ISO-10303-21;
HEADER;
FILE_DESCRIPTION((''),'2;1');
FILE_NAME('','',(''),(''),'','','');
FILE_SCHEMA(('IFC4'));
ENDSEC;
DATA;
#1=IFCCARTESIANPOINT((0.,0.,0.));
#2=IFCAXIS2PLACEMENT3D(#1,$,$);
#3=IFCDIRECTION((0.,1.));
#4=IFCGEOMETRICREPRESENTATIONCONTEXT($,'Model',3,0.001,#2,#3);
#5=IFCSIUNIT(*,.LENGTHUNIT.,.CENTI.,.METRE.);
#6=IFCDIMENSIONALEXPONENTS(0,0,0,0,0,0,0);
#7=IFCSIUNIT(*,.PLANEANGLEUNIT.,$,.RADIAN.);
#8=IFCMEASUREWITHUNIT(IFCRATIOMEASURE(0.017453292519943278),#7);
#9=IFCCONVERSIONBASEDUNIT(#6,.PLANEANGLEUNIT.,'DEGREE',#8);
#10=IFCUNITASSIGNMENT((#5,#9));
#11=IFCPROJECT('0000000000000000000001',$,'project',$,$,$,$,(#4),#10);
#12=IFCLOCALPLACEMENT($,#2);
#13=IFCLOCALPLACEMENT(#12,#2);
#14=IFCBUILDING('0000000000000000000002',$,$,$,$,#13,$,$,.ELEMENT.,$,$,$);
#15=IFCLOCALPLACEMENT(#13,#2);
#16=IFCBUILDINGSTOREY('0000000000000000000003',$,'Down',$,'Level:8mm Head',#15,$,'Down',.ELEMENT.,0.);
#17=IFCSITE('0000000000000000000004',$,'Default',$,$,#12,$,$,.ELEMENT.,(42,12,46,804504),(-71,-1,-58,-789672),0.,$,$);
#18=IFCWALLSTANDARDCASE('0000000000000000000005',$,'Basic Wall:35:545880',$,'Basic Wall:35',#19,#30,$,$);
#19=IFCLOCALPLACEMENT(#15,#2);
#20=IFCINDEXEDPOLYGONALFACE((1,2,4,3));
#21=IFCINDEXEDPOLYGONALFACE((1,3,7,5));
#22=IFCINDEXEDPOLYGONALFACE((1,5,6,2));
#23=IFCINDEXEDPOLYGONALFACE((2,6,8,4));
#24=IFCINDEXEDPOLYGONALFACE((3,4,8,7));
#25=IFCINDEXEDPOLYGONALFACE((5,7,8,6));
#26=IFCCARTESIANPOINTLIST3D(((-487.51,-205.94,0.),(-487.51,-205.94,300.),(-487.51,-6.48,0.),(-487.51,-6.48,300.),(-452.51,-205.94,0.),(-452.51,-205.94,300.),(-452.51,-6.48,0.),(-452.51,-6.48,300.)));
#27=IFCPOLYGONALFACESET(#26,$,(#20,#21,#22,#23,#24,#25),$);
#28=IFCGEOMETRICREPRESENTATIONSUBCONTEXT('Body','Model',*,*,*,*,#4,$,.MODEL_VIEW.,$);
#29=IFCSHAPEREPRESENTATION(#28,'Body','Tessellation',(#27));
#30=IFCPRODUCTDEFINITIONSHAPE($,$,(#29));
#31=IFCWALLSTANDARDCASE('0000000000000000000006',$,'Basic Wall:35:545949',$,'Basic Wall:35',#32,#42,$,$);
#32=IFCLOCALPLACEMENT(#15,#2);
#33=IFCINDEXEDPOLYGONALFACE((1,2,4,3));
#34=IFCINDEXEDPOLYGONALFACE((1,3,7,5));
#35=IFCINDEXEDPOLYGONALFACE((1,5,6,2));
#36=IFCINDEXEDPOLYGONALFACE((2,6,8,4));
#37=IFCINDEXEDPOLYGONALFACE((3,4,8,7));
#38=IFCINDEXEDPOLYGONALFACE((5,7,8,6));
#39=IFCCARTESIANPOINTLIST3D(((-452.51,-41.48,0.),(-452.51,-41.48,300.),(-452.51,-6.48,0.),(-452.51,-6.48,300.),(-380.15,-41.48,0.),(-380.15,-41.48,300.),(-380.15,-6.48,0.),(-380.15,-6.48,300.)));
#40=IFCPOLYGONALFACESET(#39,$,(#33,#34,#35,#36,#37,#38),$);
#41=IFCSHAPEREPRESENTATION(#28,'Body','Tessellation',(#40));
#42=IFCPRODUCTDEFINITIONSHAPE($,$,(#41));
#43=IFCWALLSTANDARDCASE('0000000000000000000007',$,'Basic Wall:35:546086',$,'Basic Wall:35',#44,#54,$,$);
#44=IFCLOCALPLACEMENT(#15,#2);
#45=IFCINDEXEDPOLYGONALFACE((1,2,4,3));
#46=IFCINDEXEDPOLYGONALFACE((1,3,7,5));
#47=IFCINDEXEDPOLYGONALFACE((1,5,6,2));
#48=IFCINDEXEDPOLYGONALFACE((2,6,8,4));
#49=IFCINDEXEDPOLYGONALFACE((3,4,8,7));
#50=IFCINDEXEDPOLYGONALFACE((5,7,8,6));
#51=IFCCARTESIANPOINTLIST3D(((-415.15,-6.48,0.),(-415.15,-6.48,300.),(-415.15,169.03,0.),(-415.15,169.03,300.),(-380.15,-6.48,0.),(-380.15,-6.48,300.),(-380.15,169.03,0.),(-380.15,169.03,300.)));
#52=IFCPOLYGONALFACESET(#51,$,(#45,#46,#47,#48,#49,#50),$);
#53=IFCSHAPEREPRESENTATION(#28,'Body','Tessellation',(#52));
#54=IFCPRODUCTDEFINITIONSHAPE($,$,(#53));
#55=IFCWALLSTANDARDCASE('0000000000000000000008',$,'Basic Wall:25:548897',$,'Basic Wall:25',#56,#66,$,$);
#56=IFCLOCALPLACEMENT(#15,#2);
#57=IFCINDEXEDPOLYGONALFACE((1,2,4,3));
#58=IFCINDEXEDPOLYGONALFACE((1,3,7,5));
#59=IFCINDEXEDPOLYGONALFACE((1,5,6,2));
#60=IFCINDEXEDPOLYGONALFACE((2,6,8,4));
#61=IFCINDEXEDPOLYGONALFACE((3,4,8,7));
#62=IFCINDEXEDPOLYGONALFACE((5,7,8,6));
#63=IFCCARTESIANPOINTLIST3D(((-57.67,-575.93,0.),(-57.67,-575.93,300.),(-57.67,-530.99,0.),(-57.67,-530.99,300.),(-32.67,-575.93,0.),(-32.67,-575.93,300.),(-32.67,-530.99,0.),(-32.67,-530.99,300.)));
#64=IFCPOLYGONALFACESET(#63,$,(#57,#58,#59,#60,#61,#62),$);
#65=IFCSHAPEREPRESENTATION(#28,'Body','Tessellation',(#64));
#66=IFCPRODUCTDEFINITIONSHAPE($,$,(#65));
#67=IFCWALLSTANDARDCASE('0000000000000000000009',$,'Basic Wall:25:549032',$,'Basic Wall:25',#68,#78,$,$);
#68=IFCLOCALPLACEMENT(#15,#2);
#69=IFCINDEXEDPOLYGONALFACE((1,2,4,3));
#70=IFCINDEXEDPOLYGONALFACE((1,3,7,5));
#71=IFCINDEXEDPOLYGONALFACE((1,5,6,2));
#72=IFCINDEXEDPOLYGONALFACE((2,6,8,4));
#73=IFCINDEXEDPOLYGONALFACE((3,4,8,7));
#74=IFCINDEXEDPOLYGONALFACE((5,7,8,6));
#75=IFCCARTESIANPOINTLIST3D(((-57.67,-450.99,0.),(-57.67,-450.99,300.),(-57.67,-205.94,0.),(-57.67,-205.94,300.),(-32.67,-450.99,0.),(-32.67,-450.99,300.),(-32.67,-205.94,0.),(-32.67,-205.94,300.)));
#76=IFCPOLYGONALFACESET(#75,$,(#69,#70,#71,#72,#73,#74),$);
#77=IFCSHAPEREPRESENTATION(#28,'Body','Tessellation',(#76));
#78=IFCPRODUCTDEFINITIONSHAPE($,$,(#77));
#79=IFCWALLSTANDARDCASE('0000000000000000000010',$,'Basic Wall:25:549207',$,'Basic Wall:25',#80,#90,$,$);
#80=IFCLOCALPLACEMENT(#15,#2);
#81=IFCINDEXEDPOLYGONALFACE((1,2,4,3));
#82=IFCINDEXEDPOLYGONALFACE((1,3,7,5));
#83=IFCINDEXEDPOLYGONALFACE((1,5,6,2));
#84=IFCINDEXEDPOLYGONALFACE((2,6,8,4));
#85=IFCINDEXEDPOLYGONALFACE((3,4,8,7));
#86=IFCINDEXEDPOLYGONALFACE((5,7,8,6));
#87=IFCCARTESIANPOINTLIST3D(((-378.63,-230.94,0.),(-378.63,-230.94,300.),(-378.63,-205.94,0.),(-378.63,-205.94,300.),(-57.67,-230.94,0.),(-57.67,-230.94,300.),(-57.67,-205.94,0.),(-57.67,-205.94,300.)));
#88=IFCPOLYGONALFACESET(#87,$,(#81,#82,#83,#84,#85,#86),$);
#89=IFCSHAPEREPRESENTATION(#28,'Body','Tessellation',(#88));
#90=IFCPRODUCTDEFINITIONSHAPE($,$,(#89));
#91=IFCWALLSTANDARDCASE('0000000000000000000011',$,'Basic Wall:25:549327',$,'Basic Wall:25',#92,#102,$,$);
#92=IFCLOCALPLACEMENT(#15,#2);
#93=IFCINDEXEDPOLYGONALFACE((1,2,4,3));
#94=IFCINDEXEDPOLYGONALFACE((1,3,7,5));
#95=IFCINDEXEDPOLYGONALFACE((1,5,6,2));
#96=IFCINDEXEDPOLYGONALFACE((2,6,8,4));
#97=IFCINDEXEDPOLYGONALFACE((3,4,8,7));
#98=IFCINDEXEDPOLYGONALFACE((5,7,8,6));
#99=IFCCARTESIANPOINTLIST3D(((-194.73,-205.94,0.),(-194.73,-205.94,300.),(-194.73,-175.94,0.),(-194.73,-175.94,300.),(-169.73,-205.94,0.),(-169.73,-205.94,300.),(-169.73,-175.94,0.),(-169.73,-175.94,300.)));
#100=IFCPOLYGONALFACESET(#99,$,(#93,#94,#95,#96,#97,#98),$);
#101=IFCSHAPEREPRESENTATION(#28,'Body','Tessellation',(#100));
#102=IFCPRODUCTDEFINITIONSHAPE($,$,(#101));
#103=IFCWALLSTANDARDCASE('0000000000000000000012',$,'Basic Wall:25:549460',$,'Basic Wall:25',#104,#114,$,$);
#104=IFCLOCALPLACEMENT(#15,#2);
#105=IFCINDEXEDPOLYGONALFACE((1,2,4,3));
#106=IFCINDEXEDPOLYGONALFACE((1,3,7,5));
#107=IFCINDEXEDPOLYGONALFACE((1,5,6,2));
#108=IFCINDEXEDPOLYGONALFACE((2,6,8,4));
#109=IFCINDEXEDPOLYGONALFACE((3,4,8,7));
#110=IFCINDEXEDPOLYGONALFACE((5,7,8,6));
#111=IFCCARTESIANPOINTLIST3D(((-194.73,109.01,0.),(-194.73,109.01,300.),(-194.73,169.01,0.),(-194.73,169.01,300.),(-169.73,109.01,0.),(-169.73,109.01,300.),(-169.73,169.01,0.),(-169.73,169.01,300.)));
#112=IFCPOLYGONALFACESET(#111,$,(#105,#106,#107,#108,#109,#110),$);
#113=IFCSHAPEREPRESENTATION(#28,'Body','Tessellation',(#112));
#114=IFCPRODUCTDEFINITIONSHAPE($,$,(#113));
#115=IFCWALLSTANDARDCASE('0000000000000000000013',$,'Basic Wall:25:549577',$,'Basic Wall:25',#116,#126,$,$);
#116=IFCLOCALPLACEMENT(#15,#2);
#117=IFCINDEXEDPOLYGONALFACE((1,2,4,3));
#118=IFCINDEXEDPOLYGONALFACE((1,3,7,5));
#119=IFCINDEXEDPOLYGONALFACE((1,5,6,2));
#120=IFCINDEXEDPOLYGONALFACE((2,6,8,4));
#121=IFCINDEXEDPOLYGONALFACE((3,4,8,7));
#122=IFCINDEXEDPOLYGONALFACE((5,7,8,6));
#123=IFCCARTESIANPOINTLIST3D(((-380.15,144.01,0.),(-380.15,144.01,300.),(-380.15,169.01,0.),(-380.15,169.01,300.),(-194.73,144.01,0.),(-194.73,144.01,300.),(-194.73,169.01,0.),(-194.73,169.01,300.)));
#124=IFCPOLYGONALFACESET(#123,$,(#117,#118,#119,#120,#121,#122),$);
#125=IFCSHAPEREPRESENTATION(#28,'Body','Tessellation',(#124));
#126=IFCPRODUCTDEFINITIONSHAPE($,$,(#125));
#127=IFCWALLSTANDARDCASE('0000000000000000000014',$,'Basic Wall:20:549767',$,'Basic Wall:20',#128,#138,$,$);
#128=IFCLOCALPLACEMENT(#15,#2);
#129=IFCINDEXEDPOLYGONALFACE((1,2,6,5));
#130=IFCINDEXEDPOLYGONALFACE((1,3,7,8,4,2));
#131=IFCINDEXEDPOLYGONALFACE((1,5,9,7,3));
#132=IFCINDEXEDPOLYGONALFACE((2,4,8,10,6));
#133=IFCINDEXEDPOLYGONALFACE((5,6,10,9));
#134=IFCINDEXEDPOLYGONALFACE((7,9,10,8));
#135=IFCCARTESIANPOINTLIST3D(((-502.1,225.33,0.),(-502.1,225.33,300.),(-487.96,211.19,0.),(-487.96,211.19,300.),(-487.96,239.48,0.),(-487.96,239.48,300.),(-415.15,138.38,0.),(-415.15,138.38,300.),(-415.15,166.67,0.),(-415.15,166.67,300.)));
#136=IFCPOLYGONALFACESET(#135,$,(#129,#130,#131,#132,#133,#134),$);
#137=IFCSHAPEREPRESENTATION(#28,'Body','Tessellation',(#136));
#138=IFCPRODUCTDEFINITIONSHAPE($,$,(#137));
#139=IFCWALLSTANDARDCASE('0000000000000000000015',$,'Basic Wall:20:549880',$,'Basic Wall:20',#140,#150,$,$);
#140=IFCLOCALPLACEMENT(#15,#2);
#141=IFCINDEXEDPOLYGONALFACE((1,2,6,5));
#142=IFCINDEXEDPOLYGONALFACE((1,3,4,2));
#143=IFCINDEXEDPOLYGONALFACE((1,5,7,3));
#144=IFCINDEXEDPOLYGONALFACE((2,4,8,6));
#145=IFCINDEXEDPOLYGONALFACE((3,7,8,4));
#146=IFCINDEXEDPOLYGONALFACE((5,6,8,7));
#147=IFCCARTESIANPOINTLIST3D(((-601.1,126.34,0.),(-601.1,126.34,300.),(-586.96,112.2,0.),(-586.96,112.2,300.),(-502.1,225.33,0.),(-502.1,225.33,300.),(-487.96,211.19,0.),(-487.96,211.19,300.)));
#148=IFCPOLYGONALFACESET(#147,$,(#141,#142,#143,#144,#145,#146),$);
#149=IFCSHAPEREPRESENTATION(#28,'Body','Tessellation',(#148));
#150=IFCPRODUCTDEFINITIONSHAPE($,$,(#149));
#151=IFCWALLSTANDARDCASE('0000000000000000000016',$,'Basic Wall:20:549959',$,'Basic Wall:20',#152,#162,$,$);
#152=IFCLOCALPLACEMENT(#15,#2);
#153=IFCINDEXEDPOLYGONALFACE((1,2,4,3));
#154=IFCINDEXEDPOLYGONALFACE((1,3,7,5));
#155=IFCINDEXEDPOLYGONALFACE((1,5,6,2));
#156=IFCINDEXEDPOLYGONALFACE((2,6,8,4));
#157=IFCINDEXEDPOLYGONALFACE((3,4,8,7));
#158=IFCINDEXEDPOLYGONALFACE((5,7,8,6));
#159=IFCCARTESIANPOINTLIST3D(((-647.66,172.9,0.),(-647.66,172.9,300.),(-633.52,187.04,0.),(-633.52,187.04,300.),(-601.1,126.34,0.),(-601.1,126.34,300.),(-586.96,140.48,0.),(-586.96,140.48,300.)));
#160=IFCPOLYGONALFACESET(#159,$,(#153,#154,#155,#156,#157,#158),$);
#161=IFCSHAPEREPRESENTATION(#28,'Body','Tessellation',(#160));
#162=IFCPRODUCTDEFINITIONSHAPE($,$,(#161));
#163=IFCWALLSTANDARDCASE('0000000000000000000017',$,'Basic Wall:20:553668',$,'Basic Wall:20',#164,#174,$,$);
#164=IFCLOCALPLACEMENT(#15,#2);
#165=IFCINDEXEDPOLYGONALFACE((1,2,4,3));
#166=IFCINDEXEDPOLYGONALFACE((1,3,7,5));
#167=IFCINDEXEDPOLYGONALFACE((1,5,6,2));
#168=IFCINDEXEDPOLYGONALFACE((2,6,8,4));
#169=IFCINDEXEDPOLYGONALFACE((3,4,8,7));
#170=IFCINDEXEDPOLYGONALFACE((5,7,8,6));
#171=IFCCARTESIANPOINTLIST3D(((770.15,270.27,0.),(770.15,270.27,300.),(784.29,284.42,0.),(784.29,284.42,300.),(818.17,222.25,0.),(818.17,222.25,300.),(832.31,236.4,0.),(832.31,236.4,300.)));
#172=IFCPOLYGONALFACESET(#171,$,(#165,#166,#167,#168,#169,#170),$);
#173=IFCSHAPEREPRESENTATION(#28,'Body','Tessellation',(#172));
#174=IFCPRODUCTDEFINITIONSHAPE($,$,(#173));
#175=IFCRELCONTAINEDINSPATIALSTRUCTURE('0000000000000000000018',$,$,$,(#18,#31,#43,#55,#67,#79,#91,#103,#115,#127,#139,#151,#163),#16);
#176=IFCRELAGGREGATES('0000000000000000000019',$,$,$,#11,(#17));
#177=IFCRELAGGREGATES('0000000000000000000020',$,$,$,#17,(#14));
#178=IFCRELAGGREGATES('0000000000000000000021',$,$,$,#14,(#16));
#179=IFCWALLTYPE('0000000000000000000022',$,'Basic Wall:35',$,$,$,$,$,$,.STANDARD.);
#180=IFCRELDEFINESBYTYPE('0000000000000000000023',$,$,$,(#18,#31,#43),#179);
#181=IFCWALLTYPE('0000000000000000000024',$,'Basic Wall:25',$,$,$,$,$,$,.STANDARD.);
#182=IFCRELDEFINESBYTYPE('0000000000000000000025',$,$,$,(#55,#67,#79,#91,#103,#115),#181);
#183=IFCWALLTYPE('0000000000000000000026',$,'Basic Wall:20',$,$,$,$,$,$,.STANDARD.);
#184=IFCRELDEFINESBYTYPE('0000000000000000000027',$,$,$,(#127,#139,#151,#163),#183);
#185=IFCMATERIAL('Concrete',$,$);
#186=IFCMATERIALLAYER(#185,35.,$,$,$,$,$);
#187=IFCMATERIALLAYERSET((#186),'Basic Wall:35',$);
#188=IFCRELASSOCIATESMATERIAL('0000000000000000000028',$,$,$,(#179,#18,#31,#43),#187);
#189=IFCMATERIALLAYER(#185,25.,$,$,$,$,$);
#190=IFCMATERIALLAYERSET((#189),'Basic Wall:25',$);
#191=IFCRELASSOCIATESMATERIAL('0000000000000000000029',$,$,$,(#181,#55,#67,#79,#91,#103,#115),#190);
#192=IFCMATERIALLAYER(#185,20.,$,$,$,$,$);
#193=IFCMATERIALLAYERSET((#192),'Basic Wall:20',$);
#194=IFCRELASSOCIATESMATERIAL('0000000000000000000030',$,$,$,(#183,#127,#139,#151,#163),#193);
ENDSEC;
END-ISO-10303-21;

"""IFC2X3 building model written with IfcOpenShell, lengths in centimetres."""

from ifc_helpers import new_model, entity, si_unit, converted_unit, direction, frame, frame_2d, origin, place, context, subcontext, project, spatial, polyline, rectangle, outline, extrude, material, layer, layer_set, layer_usage, type_object, element, save


model = new_model("IFC2X3")

# Units and contexts
model_context = context("Model", 3, precision=0.001, world=origin(), true_north=direction((0.0, 1.0)))
body_context = subcontext(model_context, "Body", "Model", "MODEL_VIEW")
ifc_project = project(units=[si_unit("LENGTHUNIT", "METRE", prefix="CENTI"), converted_unit("PLANEANGLEUNIT", "DEGREE", entity("IfcRatioMeasure", 0.017453292519943278), si_unit("PLANEANGLEUNIT", "RADIAN"), dimensions=[0, 0, 0, 0, 0, 0, 0])], contexts=[model_context])

# Site, building, storey
site_placement = place(None, origin())
site = spatial("IfcSite", under=ifc_project, at=site_placement, Name="Default", CompositionType="ELEMENT", RefLatitude=(42, 12, 46, 804504), RefLongitude=(-71, -1, -58, -789672), RefElevation=0.0)
building_placement = place(site_placement, origin())
building = spatial("IfcBuilding", under=site, at=building_placement, CompositionType="ELEMENT")
storey_placement = place(building_placement, origin())
storey = spatial("IfcBuildingStorey", under=building, at=storey_placement, Name="Down", ObjectType="Level:8mm Head", LongName="Down", CompositionType="ELEMENT", Elevation=0.0)

# Shared definitions
ifc_material = material(Name="Concrete")

# Walls
ifc_layer_1 = layer(ifc_material, 35.0)
ifc_layer_set_1 = layer_set([ifc_layer_1], Name="Basic Wall:35")
wall_type_1 = type_object("IfcWallType", Name="Basic Wall:35", PredefinedType="STANDARD", material=ifc_layer_set_1)
ifc_layer_usage_1 = layer_usage(ifc_layer_set_1, "AXIS2", "NEGATIVE", 17.5)
wall_1_placement = place(storey_placement, frame((-470.01, -205.94, 0.0), z_axis=(0.0, 0.0, 1.0), x_axis=(0.0, 1.0, 0.0)))
element("IfcWallStandardCase", 1, at=wall_1_placement, inside=storey, type_object=wall_type_1, material=ifc_layer_usage_1, Name="Basic Wall:35:545880", ObjectType="Basic Wall:35", context=body_context, shape_type="SweptSolid", body=[
    extrude(rectangle(XDim=199.46, YDim=35.0, at=frame_2d((99.73, 0.0), x_axis=(-1.0, 0.0))), origin(), (0.0, 0.0, 1.0), 300.0),
])
ifc_layer_usage_2 = layer_usage(ifc_layer_set_1, "AXIS2", "NEGATIVE", 17.5)
wall_2_placement = place(storey_placement, frame((-452.51, -23.98, 0.0)))
element("IfcWallStandardCase", 2, at=wall_2_placement, inside=storey, type_object=wall_type_1, material=ifc_layer_usage_2, Name="Basic Wall:35:545949", ObjectType="Basic Wall:35", context=body_context, shape_type="SweptSolid", body=[
    extrude(rectangle(XDim=72.36, YDim=35.0, at=frame_2d((36.18, 0.0), x_axis=(-1.0, 0.0))), origin(), (0.0, 0.0, 1.0), 300.0),
])
ifc_layer_usage_3 = layer_usage(ifc_layer_set_1, "AXIS2", "POSITIVE", -17.5)
wall_3_placement = place(storey_placement, frame((-397.65, -6.48, 0.0), z_axis=(0.0, 0.0, 1.0), x_axis=(0.0, 1.0, 0.0)))
element("IfcWallStandardCase", 3, at=wall_3_placement, inside=storey, type_object=wall_type_1, material=ifc_layer_usage_3, Name="Basic Wall:35:546086", ObjectType="Basic Wall:35", context=body_context, shape_type="SweptSolid", body=[
    extrude(rectangle(XDim=175.51, YDim=35.0, at=frame_2d((87.75, 0.0), x_axis=(-1.0, 0.0))), origin(), (0.0, 0.0, 1.0), 300.0),
])
ifc_layer_2 = layer(ifc_material, 25.0)
ifc_layer_set_2 = layer_set([ifc_layer_2], Name="Basic Wall:25")
ifc_layer_usage_4 = layer_usage(ifc_layer_set_2, "AXIS2", "POSITIVE", -12.5)
wall_type_2 = type_object("IfcWallType", Name="Basic Wall:25", PredefinedType="STANDARD", material=ifc_layer_set_2)
wall_4_placement = place(storey_placement, frame((-45.17, -575.93, 0.0), z_axis=(0.0, 0.0, 1.0), x_axis=(0.0, 1.0, 0.0)))
element("IfcWallStandardCase", 4, at=wall_4_placement, inside=storey, type_object=wall_type_2, material=ifc_layer_usage_4, Name="Basic Wall:25:548897", ObjectType="Basic Wall:25", context=body_context, shape_type="SweptSolid", body=[
    extrude(rectangle(XDim=44.94, YDim=25.0, at=frame_2d((22.47, 0.0), x_axis=(-1.0, 0.0))), origin(), (0.0, 0.0, 1.0), 300.0),
])
ifc_layer_usage_5 = layer_usage(ifc_layer_set_2, "AXIS2", "POSITIVE", -12.5)
wall_5_placement = place(storey_placement, frame((-45.17, -450.99, 0.0), z_axis=(0.0, 0.0, 1.0), x_axis=(0.0, 1.0, 0.0)))
element("IfcWallStandardCase", 5, at=wall_5_placement, inside=storey, type_object=wall_type_2, material=ifc_layer_usage_5, Name="Basic Wall:25:549032", ObjectType="Basic Wall:25", context=body_context, shape_type="SweptSolid", body=[
    extrude(rectangle(XDim=245.05, YDim=25.0, at=frame_2d((122.52, 0.0), x_axis=(-1.0, 0.0))), origin(), (0.0, 0.0, 1.0), 300.0),
])
ifc_layer_usage_6 = layer_usage(ifc_layer_set_2, "AXIS2", "POSITIVE", -12.5)
wall_6_placement = place(storey_placement, frame((-57.67, -218.44, 0.0), z_axis=(0.0, 0.0, 1.0), x_axis=(-1.0, 0.0, 0.0)))
element("IfcWallStandardCase", 6, at=wall_6_placement, inside=storey, type_object=wall_type_2, material=ifc_layer_usage_6, Name="Basic Wall:25:549207", ObjectType="Basic Wall:25", context=body_context, shape_type="SweptSolid", body=[
    extrude(rectangle(XDim=320.96, YDim=25.0, at=frame_2d((160.48, 0.0), x_axis=(-1.0, 0.0))), origin(), (0.0, 0.0, 1.0), 300.0),
])
ifc_layer_usage_7 = layer_usage(ifc_layer_set_2, "AXIS2", "POSITIVE", -12.5)
wall_7_placement = place(storey_placement, frame((-182.23, -205.94, 0.0), z_axis=(0.0, 0.0, 1.0), x_axis=(0.0, 1.0, 0.0)))
element("IfcWallStandardCase", 7, at=wall_7_placement, inside=storey, type_object=wall_type_2, material=ifc_layer_usage_7, Name="Basic Wall:25:549327", ObjectType="Basic Wall:25", context=body_context, shape_type="SweptSolid", body=[
    extrude(rectangle(XDim=30.0, YDim=25.0, at=frame_2d((15.0, 0.0), x_axis=(-1.0, 0.0))), origin(), (0.0, 0.0, 1.0), 300.0),
])
ifc_layer_usage_8 = layer_usage(ifc_layer_set_2, "AXIS2", "POSITIVE", -12.5)
wall_8_placement = place(storey_placement, frame((-182.23, 109.01, 0.0), z_axis=(0.0, 0.0, 1.0), x_axis=(0.0, 1.0, 0.0)))
element("IfcWallStandardCase", 8, at=wall_8_placement, inside=storey, type_object=wall_type_2, material=ifc_layer_usage_8, Name="Basic Wall:25:549460", ObjectType="Basic Wall:25", context=body_context, shape_type="SweptSolid", body=[
    extrude(rectangle(XDim=60.0, YDim=25.0, at=frame_2d((30.0, 0.0), x_axis=(-1.0, 0.0))), origin(), (0.0, 0.0, 1.0), 300.0),
])
ifc_layer_usage_9 = layer_usage(ifc_layer_set_2, "AXIS2", "POSITIVE", -12.5)
wall_9_placement = place(storey_placement, frame((-194.73, 156.51, 0.0), z_axis=(0.0, 0.0, 1.0), x_axis=(-1.0, 0.0, 0.0)))
element("IfcWallStandardCase", 9, at=wall_9_placement, inside=storey, type_object=wall_type_2, material=ifc_layer_usage_9, Name="Basic Wall:25:549577", ObjectType="Basic Wall:25", context=body_context, shape_type="SweptSolid", body=[
    extrude(rectangle(XDim=185.42, YDim=25.0, at=frame_2d((92.71, 0.0), x_axis=(-1.0, 0.0))), origin(), (0.0, 0.0, 1.0), 300.0),
])
ifc_layer_3 = layer(ifc_material, 20.0)
ifc_layer_set_3 = layer_set([ifc_layer_3], Name="Basic Wall:20")
ifc_layer_usage_10 = layer_usage(ifc_layer_set_3, "AXIS2", "NEGATIVE", 10.0)
wall_type_3 = type_object("IfcWallType", Name="Basic Wall:20", PredefinedType="STANDARD", material=ifc_layer_set_3)
wall_10_placement = place(storey_placement, frame((-408.08, 145.45, 0.0), z_axis=(0.0, 0.0, 1.0), x_axis=(-0.707107, 0.707107, 0.0)))
element("IfcWallStandardCase", 10, at=wall_10_placement, inside=storey, type_object=wall_type_3, material=ifc_layer_usage_10, Name="Basic Wall:20:549767", ObjectType="Basic Wall:20", context=body_context, shape_type="SweptSolid", body=[
    extrude(outline(polyline([(122.97, -10.0), (122.97, 10.0), (102.97, 10.0), (0.0, 10.0), (20.0, -10.0), (122.97, -10.0)])), origin(), (0.0, 0.0, 1.0), 300.0),
])
ifc_layer_usage_11 = layer_usage(ifc_layer_set_3, "AXIS2", "NEGATIVE", 10.0)
wall_11_placement = place(storey_placement, frame((-495.03, 218.26, 0.0), z_axis=(0.0, 0.0, 1.0), x_axis=(-0.707107, -0.707107, 0.0)))
element("IfcWallStandardCase", 11, at=wall_11_placement, inside=storey, type_object=wall_type_3, material=ifc_layer_usage_11, Name="Basic Wall:20:549880", ObjectType="Basic Wall:20", context=body_context, shape_type="SweptSolid", body=[
    extrude(rectangle(XDim=140.0, YDim=20.0, at=frame_2d((70.0, 0.0), x_axis=(-1.0, 0.0))), origin(), (0.0, 0.0, 1.0), 300.0),
])
ifc_layer_usage_12 = layer_usage(ifc_layer_set_3, "AXIS2", "NEGATIVE", 10.0)
wall_12_placement = place(storey_placement, frame((-594.03, 133.41, 0.0), z_axis=(0.0, 0.0, 1.0), x_axis=(-0.707107, 0.707107, 0.0)))
element("IfcWallStandardCase", 12, at=wall_12_placement, inside=storey, type_object=wall_type_3, material=ifc_layer_usage_12, Name="Basic Wall:20:549959", ObjectType="Basic Wall:20", context=body_context, shape_type="SweptSolid", body=[
    extrude(rectangle(XDim=65.85, YDim=20.0, at=frame_2d((32.92, 0.0), x_axis=(-1.0, 0.0))), origin(), (0.0, 0.0, 1.0), 300.0),
])
ifc_layer_usage_13 = layer_usage(ifc_layer_set_3, "AXIS2", "NEGATIVE", 10.0)
wall_13_placement = place(storey_placement, frame((825.24, 229.33, 0.0), z_axis=(0.0, 0.0, 1.0), x_axis=(-0.707107, 0.707107, 0.0)))
element("IfcWallStandardCase", 13, at=wall_13_placement, inside=storey, type_object=wall_type_3, material=ifc_layer_usage_13, Name="Basic Wall:20:553668", ObjectType="Basic Wall:20", context=body_context, shape_type="SweptSolid", body=[
    extrude(rectangle(XDim=67.91, YDim=20.0, at=frame_2d((33.96, 0.0), x_axis=(-1.0, 0.0))), origin(), (0.0, 0.0, 1.0), 300.0),
])

save(model, "model.ifc")
